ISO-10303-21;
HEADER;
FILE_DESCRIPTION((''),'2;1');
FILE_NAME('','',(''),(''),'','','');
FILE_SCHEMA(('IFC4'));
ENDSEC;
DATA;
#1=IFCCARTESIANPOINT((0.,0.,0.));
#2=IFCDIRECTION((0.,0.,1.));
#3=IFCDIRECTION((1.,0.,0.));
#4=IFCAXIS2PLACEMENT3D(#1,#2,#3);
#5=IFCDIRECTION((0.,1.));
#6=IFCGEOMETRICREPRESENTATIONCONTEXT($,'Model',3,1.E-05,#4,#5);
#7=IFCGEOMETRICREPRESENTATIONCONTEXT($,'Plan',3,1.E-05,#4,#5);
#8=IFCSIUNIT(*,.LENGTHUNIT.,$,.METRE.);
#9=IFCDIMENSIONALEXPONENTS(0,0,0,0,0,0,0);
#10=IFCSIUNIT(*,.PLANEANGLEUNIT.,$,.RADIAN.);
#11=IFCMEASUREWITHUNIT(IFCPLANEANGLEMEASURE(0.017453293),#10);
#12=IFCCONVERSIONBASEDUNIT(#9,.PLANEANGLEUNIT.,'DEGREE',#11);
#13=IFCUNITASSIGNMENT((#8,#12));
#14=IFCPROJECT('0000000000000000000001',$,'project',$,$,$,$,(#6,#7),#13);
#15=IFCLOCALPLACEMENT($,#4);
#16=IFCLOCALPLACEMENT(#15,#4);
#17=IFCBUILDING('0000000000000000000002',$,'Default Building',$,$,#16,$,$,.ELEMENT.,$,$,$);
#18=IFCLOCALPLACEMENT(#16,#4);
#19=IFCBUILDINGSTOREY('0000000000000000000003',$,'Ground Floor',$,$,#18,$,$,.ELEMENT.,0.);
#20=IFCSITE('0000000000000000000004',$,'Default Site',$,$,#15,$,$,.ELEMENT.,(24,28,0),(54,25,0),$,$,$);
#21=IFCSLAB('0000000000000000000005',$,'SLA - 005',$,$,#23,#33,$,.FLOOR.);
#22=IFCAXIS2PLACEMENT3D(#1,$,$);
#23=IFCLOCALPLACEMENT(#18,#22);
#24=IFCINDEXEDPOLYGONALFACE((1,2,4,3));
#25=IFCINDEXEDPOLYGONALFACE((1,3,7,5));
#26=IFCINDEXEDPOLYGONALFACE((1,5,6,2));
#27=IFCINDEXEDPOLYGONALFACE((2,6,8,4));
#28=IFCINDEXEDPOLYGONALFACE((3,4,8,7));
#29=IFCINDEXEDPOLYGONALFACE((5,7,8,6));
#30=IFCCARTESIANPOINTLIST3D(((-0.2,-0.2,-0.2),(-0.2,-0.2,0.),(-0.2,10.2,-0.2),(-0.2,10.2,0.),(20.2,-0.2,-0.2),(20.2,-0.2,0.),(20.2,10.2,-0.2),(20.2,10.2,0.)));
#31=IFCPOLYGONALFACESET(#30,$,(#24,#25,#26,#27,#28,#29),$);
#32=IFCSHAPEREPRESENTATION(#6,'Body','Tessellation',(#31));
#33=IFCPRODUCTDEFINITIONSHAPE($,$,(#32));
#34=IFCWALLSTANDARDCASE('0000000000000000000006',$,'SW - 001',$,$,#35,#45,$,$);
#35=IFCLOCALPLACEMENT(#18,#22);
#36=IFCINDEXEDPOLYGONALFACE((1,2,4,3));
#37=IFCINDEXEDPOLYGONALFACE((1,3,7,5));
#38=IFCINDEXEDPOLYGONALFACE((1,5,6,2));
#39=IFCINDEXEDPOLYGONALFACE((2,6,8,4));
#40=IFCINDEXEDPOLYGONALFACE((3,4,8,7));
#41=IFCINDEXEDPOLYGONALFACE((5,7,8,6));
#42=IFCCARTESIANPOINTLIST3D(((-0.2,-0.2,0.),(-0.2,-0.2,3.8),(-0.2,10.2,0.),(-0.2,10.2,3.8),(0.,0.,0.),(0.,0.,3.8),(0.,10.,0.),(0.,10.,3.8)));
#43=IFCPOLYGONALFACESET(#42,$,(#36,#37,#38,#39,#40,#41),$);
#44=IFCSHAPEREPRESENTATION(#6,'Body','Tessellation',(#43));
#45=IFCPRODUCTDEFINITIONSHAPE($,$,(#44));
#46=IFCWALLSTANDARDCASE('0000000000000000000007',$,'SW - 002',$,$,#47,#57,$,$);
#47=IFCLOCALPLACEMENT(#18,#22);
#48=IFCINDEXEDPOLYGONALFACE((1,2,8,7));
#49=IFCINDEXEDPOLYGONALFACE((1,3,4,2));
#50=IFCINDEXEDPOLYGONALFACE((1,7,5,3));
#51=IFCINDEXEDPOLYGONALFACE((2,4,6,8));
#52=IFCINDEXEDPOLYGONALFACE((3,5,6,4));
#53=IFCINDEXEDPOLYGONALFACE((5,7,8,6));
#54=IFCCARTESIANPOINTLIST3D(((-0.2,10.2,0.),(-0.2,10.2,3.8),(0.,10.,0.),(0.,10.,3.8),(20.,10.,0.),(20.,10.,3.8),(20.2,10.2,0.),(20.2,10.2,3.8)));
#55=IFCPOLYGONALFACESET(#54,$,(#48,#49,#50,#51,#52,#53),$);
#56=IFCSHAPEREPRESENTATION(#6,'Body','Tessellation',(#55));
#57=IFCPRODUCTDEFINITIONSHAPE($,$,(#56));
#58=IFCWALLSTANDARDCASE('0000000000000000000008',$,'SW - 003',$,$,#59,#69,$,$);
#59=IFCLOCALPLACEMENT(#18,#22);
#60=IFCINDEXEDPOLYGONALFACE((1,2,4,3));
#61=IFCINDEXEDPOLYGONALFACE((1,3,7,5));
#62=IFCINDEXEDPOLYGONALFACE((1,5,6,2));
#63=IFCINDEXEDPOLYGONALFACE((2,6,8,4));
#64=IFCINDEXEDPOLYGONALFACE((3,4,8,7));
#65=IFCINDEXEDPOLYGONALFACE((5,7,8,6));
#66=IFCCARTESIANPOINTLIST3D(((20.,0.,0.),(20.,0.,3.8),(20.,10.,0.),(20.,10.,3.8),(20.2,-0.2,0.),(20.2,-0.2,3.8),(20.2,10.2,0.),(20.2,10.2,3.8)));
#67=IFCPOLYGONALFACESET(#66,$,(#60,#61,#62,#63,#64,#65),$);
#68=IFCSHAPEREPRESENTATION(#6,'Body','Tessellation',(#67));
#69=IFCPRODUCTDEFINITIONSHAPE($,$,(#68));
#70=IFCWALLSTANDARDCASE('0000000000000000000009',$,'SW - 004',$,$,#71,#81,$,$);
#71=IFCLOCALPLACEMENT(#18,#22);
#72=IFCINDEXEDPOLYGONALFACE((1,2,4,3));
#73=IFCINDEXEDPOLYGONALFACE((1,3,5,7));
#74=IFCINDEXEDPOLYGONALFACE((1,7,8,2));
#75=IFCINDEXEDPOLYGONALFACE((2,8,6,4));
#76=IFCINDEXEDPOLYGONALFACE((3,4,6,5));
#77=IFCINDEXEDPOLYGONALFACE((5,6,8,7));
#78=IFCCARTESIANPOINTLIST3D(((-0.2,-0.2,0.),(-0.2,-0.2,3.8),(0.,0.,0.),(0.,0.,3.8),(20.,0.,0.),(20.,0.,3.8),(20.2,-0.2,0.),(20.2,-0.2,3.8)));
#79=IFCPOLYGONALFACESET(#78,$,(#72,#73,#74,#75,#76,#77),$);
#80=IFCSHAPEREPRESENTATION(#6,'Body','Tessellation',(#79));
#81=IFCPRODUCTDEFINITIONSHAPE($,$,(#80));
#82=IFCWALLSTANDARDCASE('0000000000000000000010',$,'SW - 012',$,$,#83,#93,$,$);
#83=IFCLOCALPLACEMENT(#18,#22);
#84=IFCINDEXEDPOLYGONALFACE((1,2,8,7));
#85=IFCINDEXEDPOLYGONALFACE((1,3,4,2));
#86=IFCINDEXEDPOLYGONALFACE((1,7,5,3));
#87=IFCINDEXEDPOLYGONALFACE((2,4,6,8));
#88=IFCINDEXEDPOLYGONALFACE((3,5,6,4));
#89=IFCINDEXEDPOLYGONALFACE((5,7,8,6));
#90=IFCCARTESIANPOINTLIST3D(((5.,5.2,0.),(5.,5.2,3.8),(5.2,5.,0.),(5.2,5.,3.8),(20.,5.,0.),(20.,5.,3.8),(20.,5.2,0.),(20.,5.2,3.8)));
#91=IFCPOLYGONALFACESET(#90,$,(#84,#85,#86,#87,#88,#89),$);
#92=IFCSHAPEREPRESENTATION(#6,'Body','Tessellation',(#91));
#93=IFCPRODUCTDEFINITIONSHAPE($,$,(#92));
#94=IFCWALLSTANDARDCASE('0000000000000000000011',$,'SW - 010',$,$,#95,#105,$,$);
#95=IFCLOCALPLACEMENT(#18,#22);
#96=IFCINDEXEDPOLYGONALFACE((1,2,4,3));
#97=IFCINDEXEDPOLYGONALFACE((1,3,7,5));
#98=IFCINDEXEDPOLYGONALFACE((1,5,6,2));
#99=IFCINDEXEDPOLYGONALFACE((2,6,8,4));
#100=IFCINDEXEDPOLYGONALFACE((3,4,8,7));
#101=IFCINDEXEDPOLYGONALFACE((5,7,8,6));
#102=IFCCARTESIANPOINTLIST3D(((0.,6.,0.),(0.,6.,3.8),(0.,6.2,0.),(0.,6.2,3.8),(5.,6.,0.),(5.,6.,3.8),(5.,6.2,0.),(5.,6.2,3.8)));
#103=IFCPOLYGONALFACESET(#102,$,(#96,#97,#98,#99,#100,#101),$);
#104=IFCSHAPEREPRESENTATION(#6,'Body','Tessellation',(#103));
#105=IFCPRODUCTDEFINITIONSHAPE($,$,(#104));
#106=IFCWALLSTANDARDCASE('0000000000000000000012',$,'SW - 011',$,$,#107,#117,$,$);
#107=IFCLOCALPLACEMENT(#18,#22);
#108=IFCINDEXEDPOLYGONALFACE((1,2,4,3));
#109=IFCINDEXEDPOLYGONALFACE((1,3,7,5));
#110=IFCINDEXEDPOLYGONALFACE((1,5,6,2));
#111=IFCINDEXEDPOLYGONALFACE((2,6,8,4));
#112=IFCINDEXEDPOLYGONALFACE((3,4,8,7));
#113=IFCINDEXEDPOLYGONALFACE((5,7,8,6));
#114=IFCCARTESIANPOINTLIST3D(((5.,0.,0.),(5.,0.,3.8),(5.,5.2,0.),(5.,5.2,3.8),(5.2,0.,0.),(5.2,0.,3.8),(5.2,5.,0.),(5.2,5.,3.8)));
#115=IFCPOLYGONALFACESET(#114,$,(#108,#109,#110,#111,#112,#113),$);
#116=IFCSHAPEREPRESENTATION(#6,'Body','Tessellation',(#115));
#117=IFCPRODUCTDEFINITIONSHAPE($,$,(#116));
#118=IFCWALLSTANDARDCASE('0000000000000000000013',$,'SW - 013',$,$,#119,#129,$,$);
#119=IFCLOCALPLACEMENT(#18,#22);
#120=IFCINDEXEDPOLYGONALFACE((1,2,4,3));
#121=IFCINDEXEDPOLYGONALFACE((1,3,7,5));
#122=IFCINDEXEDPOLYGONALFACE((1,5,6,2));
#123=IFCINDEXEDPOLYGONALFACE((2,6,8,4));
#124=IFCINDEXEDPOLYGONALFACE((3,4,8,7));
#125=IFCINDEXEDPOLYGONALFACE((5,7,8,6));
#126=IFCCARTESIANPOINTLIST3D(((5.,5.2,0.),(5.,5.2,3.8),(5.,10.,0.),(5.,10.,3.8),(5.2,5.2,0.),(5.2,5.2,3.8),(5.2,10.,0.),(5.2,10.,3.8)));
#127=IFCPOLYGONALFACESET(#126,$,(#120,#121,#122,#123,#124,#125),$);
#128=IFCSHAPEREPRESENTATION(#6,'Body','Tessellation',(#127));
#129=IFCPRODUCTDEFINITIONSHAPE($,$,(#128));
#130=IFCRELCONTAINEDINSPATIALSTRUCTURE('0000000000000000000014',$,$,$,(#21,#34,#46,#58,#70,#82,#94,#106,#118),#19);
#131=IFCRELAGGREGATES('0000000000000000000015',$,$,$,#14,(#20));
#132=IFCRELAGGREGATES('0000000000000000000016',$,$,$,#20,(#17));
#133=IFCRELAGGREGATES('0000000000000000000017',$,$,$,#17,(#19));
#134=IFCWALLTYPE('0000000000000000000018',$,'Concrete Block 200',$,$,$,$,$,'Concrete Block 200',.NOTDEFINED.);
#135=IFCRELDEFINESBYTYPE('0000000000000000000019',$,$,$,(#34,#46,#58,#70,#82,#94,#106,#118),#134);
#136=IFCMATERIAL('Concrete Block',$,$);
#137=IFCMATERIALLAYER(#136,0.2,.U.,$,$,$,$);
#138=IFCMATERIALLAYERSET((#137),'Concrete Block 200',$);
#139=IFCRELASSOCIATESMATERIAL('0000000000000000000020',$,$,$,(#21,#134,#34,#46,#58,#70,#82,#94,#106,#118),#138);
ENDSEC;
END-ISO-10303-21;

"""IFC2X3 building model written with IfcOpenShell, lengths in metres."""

from ifc_helpers import new_model, entity, si_unit, converted_unit, direction, frame, origin_with_axes, place, context, project, spatial, polyline, outline, extrude, material, layer, layer_set, layer_usage, type_object, element, save


model = new_model("IFC2X3")

# Units and contexts
model_context = context("Model", 3, precision=1e-05, world=origin_with_axes(), true_north=direction((0.0, 1.0)))
plan_context = context("Plan", 3, precision=1e-05, world=origin_with_axes(), true_north=direction((0.0, 1.0)))
ifc_project = project(units=[si_unit("LENGTHUNIT", "METRE"), converted_unit("PLANEANGLEUNIT", "DEGREE", entity("IfcPlaneAngleMeasure", 0.017453293), si_unit("PLANEANGLEUNIT", "RADIAN"), dimensions=[0, 0, 0, 0, 0, 0, 0])], contexts=[model_context, plan_context])

# Site, building, storey
site_placement = place(None, origin_with_axes())
site = spatial("IfcSite", under=ifc_project, at=site_placement, Name="Default Site", CompositionType="ELEMENT", RefLatitude=(24, 28, 0), RefLongitude=(54, 25, 0))
building_placement = place(site_placement, origin_with_axes())
building = spatial("IfcBuilding", under=site, at=building_placement, Name="Default Building", CompositionType="ELEMENT")
storey_placement = place(building_placement, origin_with_axes())
storey = spatial("IfcBuildingStorey", under=building, at=storey_placement, Name="Ground Floor", CompositionType="ELEMENT", Elevation=0.0)

# Slab
ifc_material = material(Name="Concrete Block")
ifc_layer = layer(ifc_material, 0.2, ventilated="UNKNOWN")
ifc_layer_set = layer_set([ifc_layer], Name="Concrete Block 200")
ifc_layer_usage_1 = layer_usage(ifc_layer_set, "AXIS3", "NEGATIVE", 0.2)
slab_placement = place(storey_placement, frame((-0.2, 10.2, -0.2), z_axis=(0.0, 0.0, 1.0), x_axis=(1.0, 0.0, 0.0)))
element("IfcSlab", 1, at=slab_placement, inside=storey, material=ifc_layer_usage_1, Name="SLA - 005", PredefinedType="FLOOR", context=model_context, shape_type="SweptSolid", body=[
    extrude(outline(polyline([(0.0, 0.0), (20.4, 0.0), (20.4, -10.4), (0.0, -10.4), (0.0, 0.0)])), origin_with_axes(), (0.0, 0.0, 1.0), 0.2),
])

# Walls
ifc_layer_usage_2 = layer_usage(ifc_layer_set, "AXIS2", "POSITIVE", 0.0)
wall_type = type_object("IfcWallType", Name="Concrete Block 200", ElementType="Concrete Block 200", PredefinedType="NOTDEFINED", material=ifc_layer_set)
wall_1_placement = place(storey_placement, frame((0.0, 0.0, 0.0), z_axis=(0.0, 0.0, 1.0), x_axis=(0.0, 1.0, 0.0)))
element("IfcWallStandardCase", 2, at=wall_1_placement, inside=storey, type_object=wall_type, material=ifc_layer_usage_2, Name="SW - 001", context=model_context, shape_type="SweptSolid", body=[
    extrude(outline(polyline([(0.0, 0.0), (10.0, 0.0), (10.2, 0.2), (-0.2, 0.2), (0.0, 0.0)])), origin_with_axes(), (0.0, 0.0, 1.0), 3.8),
])
ifc_layer_usage_3 = layer_usage(ifc_layer_set, "AXIS2", "POSITIVE", 0.0)
wall_2_placement = place(storey_placement, frame((0.0, 10.0, 0.0), z_axis=(0.0, 0.0, 1.0), x_axis=(1.0, 0.0, 0.0)))
element("IfcWallStandardCase", 3, at=wall_2_placement, inside=storey, type_object=wall_type, material=ifc_layer_usage_3, Name="SW - 002", context=model_context, shape_type="SweptSolid", body=[
    extrude(outline(polyline([(0.0, 0.0), (20.0, 0.0), (20.2, 0.2), (-0.2, 0.2), (0.0, 0.0)])), origin_with_axes(), (0.0, 0.0, 1.0), 3.8),
])
ifc_layer_usage_4 = layer_usage(ifc_layer_set, "AXIS2", "POSITIVE", 0.0)
wall_3_placement = place(storey_placement, frame((20.0, 10.0, 0.0), z_axis=(0.0, 0.0, 1.0), x_axis=(0.0, -1.0, 0.0)))
element("IfcWallStandardCase", 4, at=wall_3_placement, inside=storey, type_object=wall_type, material=ifc_layer_usage_4, Name="SW - 003", context=model_context, shape_type="SweptSolid", body=[
    extrude(outline(polyline([(0.0, 0.0), (10.0, 0.0), (10.2, 0.2), (-0.2, 0.2), (0.0, 0.0)])), origin_with_axes(), (0.0, 0.0, 1.0), 3.8),
])
ifc_layer_usage_5 = layer_usage(ifc_layer_set, "AXIS2", "POSITIVE", 0.0)
wall_4_placement = place(storey_placement, frame((20.0, 0.0, 0.0), z_axis=(0.0, 0.0, 1.0), x_axis=(-1.0, 0.0, 0.0)))
element("IfcWallStandardCase", 5, at=wall_4_placement, inside=storey, type_object=wall_type, material=ifc_layer_usage_5, Name="SW - 004", context=model_context, shape_type="SweptSolid", body=[
    extrude(outline(polyline([(0.0, 0.0), (20.0, 0.0), (20.2, 0.2), (-0.2, 0.2), (0.0, 0.0)])), origin_with_axes(), (0.0, 0.0, 1.0), 3.8),
])
ifc_layer_usage_6 = layer_usage(ifc_layer_set, "AXIS2", "POSITIVE", 0.0)
wall_5_placement = place(storey_placement, frame((5.0, 5.0, 0.0), z_axis=(0.0, 0.0, 1.0), x_axis=(1.0, 0.0, 0.0)))
element("IfcWallStandardCase", 6, at=wall_5_placement, inside=storey, type_object=wall_type, material=ifc_layer_usage_6, Name="SW - 012", context=model_context, shape_type="SweptSolid", body=[
    extrude(outline(polyline([(0.2, 0.0), (15.0, 0.0), (15.0, 0.2), (0.0, 0.2), (0.2, 0.0)])), origin_with_axes(), (0.0, 0.0, 1.0), 3.8),
])
ifc_layer_usage_7 = layer_usage(ifc_layer_set, "AXIS2", "POSITIVE", 0.0)
wall_6_placement = place(storey_placement, frame((0.0, 6.0, 0.0), z_axis=(0.0, 0.0, 1.0), x_axis=(1.0, 0.0, 0.0)))
element("IfcWallStandardCase", 7, at=wall_6_placement, inside=storey, type_object=wall_type, material=ifc_layer_usage_7, Name="SW - 010", context=model_context, shape_type="SweptSolid", body=[
    extrude(outline(polyline([(0.0, 0.0), (5.0, 0.0), (5.0, 0.2), (0.0, 0.2), (0.0, 0.0)])), origin_with_axes(), (0.0, 0.0, 1.0), 3.8),
])
ifc_layer_usage_8 = layer_usage(ifc_layer_set, "AXIS2", "POSITIVE", 0.0)
wall_7_placement = place(storey_placement, frame((5.0, 5.0, 0.0), z_axis=(0.0, 0.0, 1.0), x_axis=(0.0, -1.0, 0.0)))
element("IfcWallStandardCase", 8, at=wall_7_placement, inside=storey, type_object=wall_type, material=ifc_layer_usage_8, Name="SW - 011", context=model_context, shape_type="SweptSolid", body=[
    extrude(outline(polyline([(-0.2, 0.0), (5.0, 0.0), (5.0, 0.2), (0.0, 0.2), (-0.2, 0.0)])), origin_with_axes(), (0.0, 0.0, 1.0), 3.8),
])
ifc_layer_usage_9 = layer_usage(ifc_layer_set, "AXIS2", "NEGATIVE", 0.0)
wall_8_placement = place(storey_placement, frame((5.2, 10.0, 0.0), z_axis=(0.0, 0.0, 1.0), x_axis=(0.0, -1.0, 0.0)))
element("IfcWallStandardCase", 9, at=wall_8_placement, inside=storey, type_object=wall_type, material=ifc_layer_usage_9, Name="SW - 013", context=model_context, shape_type="SweptSolid", body=[
    extrude(outline(polyline([(0.0, -0.2), (4.8, -0.2), (4.8, 0.0), (0.0, 0.0), (0.0, -0.2)])), origin_with_axes(), (0.0, 0.0, 1.0), 3.8),
])

save(model, "model.ifc")
